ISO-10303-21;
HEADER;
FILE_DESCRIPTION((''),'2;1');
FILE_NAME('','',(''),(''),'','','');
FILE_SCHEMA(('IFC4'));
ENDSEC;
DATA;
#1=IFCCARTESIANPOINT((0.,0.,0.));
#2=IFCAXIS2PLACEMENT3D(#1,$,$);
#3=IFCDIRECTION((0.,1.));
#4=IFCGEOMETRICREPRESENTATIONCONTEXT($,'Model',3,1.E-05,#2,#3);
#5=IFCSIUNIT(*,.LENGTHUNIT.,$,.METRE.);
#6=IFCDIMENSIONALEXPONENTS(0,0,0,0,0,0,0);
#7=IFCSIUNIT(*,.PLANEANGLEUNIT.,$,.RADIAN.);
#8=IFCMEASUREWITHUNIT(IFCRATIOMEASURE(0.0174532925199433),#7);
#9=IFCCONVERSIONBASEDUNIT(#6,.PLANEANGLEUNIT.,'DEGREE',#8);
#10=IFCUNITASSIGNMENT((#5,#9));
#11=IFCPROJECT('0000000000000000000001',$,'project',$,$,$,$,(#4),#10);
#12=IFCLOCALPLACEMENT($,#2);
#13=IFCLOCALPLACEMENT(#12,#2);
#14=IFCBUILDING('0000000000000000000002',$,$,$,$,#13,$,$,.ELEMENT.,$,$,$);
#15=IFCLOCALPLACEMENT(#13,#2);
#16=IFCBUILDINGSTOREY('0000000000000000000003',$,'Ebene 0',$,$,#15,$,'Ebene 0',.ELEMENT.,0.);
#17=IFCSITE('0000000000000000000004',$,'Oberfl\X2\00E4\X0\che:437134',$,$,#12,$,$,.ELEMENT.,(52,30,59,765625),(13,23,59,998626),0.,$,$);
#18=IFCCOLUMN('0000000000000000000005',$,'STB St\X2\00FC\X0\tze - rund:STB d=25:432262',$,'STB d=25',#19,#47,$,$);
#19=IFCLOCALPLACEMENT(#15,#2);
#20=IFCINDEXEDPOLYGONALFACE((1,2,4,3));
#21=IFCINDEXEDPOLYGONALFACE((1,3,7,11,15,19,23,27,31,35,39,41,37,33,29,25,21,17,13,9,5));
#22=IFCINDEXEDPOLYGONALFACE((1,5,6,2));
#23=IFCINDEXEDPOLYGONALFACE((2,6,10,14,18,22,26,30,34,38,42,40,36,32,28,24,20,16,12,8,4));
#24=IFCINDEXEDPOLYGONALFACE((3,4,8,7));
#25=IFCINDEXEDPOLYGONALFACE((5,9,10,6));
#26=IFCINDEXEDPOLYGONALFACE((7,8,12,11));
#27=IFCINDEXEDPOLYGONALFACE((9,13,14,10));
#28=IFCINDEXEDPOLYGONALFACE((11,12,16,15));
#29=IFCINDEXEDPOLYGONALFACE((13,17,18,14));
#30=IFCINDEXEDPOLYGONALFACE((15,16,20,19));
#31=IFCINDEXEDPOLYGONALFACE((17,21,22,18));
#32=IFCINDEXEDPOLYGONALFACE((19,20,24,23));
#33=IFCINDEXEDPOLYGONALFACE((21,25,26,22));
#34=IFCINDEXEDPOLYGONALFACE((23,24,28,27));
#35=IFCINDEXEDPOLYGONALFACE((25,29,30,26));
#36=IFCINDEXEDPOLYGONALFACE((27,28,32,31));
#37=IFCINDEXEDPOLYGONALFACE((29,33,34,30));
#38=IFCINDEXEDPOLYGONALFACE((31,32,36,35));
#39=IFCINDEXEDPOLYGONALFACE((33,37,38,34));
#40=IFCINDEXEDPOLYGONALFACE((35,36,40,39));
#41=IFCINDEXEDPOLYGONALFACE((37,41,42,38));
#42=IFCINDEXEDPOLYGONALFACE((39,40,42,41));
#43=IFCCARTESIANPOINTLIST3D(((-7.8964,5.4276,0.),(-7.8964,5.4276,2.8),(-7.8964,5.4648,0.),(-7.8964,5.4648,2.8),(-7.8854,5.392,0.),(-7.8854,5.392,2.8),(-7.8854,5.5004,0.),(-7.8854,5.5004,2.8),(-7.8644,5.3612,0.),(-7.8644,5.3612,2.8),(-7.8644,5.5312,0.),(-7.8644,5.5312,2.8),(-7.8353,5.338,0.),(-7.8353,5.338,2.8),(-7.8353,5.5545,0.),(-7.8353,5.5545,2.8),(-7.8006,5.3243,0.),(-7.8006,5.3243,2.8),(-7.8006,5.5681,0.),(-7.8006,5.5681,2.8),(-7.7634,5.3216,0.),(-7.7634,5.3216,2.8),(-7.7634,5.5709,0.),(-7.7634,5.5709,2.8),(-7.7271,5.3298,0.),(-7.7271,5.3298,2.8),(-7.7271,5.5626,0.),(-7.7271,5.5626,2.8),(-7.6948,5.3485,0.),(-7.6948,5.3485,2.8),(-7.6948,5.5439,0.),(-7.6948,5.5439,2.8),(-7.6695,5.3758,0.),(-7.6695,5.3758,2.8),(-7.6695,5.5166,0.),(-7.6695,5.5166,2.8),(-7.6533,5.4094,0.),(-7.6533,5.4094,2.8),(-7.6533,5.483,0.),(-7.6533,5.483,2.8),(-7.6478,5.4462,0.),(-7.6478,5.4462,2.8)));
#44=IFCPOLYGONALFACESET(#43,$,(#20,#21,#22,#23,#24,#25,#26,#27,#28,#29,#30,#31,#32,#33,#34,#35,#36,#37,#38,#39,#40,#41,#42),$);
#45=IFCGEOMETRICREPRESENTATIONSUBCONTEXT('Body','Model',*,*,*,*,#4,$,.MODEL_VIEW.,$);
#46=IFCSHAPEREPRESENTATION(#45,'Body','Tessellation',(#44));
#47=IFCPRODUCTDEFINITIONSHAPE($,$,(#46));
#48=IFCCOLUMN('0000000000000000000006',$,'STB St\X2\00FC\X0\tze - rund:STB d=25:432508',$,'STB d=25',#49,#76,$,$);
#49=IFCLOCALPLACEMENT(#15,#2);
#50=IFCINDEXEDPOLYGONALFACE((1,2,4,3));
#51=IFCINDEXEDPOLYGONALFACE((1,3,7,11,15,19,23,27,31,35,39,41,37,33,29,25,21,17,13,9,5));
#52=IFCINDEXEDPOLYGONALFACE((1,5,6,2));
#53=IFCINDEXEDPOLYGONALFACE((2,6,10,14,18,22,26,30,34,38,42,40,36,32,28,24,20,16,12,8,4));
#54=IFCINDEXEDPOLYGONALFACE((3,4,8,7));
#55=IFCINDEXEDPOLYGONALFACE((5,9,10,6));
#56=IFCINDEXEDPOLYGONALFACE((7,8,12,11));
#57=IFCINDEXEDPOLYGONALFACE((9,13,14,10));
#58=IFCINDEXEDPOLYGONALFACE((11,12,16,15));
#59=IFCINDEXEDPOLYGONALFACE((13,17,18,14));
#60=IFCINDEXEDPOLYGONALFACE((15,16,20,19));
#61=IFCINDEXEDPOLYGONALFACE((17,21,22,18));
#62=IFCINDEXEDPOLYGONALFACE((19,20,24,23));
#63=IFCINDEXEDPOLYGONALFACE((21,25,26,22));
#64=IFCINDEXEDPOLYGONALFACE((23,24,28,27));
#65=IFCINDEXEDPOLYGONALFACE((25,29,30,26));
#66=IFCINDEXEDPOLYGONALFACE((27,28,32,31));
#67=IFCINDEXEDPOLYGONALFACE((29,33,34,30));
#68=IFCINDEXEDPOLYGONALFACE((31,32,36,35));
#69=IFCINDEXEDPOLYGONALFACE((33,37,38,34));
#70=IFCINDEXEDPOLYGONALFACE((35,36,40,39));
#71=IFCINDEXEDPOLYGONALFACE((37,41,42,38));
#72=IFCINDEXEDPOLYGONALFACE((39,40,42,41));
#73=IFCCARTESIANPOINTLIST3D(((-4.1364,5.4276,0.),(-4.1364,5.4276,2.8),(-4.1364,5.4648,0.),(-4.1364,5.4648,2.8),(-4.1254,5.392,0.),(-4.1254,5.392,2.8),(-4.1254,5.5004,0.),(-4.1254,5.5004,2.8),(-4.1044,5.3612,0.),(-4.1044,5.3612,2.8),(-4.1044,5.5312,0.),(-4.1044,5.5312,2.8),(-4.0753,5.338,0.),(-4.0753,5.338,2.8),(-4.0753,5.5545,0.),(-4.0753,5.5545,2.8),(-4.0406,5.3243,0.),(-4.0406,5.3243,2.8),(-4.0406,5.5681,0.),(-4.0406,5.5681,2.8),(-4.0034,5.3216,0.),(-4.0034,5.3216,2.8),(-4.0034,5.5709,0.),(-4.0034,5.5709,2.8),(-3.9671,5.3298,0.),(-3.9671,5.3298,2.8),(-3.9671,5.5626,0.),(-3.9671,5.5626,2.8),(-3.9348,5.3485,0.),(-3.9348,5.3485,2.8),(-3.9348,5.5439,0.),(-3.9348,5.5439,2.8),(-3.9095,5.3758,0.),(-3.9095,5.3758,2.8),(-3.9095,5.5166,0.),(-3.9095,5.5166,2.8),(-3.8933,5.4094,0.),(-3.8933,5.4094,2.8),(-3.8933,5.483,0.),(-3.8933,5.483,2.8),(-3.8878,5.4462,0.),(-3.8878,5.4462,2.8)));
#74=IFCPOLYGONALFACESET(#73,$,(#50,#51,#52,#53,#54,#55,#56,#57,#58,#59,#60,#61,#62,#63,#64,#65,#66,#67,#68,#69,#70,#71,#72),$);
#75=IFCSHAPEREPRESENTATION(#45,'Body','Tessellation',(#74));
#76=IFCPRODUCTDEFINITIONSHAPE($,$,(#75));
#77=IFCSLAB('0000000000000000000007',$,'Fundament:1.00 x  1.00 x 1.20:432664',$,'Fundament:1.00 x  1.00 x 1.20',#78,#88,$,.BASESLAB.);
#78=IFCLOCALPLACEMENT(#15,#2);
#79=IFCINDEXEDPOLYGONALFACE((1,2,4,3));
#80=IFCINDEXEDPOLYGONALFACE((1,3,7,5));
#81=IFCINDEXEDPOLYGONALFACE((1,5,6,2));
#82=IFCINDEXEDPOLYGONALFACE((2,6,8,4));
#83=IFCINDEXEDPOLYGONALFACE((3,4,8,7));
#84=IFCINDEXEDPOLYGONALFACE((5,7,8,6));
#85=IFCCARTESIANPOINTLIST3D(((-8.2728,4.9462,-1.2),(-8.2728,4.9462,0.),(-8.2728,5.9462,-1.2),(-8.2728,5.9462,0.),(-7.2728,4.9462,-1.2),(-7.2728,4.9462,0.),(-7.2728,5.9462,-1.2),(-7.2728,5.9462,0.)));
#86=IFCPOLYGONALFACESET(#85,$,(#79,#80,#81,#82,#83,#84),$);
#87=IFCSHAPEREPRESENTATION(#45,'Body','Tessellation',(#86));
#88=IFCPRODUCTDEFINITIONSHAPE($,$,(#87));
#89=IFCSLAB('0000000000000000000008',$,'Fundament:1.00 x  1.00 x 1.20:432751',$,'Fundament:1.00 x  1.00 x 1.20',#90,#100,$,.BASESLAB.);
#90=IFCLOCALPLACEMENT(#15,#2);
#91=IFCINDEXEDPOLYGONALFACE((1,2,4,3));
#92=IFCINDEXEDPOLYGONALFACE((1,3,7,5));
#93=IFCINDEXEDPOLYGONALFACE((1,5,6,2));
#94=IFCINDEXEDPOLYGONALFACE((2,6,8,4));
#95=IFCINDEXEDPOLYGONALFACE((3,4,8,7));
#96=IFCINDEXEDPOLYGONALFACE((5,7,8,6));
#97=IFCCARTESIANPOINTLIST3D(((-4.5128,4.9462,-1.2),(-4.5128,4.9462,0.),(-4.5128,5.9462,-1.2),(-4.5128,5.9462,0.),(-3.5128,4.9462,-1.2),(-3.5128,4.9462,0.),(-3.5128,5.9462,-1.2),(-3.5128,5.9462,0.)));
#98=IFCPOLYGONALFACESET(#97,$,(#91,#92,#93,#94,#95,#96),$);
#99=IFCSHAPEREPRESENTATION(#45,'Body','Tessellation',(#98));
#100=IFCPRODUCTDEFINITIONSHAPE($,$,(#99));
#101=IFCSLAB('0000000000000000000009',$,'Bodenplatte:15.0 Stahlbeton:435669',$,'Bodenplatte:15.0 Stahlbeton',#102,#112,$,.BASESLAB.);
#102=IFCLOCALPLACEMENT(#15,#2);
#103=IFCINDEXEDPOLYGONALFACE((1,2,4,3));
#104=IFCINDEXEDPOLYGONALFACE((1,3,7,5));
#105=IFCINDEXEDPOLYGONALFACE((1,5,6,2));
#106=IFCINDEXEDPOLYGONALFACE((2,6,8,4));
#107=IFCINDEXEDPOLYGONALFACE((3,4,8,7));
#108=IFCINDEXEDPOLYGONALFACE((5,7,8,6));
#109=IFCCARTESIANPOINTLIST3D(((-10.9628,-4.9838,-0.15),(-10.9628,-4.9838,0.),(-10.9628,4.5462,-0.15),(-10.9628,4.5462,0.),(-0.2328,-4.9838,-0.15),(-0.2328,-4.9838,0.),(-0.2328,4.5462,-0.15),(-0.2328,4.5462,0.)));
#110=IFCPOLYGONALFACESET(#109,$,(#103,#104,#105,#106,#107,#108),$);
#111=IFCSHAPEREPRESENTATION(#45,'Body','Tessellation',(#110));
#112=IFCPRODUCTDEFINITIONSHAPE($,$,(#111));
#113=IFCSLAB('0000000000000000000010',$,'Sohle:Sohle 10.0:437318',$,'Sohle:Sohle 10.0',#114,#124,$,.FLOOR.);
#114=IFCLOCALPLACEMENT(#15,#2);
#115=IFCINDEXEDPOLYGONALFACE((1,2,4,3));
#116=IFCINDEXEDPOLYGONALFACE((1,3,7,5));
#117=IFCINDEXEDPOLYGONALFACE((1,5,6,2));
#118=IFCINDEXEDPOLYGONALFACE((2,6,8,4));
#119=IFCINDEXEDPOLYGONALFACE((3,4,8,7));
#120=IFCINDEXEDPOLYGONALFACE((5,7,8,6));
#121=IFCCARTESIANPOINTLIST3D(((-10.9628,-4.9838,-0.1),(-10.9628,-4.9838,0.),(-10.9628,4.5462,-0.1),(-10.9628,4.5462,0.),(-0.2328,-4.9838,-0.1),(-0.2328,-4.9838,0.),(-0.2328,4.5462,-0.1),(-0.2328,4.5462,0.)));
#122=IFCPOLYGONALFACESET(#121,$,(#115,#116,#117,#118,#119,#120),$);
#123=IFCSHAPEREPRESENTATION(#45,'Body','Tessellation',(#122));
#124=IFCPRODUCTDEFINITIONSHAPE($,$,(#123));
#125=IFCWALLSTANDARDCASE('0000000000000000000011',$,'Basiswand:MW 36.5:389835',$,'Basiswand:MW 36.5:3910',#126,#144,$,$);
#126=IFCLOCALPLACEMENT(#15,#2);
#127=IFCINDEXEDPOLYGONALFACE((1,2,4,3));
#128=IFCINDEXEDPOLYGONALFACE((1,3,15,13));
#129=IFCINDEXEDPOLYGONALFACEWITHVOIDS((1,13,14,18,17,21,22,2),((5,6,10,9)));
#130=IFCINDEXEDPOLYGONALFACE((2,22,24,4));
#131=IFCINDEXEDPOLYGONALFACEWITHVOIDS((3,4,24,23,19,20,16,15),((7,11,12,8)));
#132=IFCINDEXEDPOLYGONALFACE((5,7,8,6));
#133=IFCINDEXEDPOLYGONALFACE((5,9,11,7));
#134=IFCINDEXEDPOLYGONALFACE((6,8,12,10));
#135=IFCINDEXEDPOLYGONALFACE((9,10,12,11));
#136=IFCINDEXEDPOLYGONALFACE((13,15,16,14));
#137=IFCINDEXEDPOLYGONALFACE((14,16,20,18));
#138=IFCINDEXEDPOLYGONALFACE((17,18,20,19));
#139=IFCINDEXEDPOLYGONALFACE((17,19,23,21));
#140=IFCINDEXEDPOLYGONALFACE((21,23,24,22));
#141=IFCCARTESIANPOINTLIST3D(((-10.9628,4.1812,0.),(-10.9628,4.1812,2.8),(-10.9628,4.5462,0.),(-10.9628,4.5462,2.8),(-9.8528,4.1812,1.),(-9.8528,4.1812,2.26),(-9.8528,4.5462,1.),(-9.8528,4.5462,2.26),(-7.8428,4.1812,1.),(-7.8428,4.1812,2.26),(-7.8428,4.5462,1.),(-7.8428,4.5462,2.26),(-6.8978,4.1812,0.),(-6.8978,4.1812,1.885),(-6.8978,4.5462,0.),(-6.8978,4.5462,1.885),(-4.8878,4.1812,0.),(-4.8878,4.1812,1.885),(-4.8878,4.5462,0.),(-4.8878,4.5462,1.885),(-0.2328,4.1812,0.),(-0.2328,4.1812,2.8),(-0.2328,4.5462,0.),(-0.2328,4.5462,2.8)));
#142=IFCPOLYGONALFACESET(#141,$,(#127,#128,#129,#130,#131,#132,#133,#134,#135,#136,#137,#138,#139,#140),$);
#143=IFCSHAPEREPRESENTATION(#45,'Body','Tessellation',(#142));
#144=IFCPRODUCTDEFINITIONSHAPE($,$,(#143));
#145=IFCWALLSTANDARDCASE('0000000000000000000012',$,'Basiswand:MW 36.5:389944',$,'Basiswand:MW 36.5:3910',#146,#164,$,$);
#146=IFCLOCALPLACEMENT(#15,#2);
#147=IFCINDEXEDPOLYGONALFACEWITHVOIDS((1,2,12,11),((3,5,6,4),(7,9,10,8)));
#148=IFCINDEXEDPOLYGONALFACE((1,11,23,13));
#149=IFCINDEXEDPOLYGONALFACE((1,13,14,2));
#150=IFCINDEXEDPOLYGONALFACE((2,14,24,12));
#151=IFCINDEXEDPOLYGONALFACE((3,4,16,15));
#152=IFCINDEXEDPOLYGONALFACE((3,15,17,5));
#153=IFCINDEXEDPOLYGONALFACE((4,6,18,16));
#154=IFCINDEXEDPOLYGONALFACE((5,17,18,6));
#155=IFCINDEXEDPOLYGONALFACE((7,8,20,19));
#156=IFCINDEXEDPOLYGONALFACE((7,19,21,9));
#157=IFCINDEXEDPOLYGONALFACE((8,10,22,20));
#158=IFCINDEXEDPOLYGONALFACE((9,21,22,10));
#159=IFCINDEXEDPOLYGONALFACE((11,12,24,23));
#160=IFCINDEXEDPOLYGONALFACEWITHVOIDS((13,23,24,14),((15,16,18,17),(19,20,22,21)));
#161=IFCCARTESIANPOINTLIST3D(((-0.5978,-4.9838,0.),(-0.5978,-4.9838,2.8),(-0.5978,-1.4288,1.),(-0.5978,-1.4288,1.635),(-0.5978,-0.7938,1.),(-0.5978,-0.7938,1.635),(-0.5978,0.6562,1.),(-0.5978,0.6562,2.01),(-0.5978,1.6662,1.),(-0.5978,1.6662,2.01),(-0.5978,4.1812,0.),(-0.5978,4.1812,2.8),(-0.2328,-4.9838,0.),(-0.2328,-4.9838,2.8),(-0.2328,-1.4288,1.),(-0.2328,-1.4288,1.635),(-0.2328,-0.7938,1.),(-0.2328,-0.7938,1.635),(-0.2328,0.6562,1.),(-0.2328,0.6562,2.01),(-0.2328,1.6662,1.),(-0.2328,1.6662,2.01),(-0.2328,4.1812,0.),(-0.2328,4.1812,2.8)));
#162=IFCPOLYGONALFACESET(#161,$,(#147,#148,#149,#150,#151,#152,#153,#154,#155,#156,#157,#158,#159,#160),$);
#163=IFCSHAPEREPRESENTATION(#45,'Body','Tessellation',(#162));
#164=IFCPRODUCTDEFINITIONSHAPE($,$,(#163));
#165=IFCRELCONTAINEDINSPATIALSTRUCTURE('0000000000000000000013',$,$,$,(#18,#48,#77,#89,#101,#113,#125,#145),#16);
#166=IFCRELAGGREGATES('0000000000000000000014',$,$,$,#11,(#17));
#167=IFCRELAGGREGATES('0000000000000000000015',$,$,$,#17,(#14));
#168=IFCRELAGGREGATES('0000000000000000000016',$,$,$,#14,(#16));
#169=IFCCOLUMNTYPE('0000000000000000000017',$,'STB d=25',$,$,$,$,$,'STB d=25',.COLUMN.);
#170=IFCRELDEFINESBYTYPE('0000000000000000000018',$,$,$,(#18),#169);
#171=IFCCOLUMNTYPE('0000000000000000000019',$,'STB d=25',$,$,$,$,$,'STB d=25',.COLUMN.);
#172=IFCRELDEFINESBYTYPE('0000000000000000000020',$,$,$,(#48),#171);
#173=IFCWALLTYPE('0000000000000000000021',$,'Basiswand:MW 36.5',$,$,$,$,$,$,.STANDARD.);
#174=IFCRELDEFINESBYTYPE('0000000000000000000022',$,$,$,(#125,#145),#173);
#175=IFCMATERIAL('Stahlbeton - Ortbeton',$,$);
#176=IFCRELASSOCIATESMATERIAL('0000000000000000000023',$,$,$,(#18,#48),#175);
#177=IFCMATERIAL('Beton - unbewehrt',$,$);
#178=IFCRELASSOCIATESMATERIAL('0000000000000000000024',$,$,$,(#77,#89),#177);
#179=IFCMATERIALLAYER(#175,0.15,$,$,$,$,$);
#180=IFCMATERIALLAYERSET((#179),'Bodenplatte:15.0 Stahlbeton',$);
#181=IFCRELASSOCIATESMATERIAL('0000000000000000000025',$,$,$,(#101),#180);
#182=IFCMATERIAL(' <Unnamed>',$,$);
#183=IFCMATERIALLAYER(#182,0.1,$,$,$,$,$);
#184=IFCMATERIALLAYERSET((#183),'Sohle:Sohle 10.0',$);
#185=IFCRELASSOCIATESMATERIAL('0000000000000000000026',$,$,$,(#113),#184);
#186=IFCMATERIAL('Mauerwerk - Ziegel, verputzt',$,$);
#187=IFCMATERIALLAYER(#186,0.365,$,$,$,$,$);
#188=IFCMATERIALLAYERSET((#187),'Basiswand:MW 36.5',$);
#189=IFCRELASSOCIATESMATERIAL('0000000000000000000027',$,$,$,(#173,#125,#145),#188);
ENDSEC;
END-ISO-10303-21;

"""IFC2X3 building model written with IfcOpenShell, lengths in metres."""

from ifc_helpers import new_model, entity, si_unit, converted_unit, direction, frame, frame_2d, origin, origin_2d_with_axis, place, context, subcontext, project, spatial, polyline, rectangle, circle, extrude, clip, bounded_halfspace, source, transform, mapped, material, layer, layer_set, layer_usage, type_object, type_shapes, element, save


model = new_model("IFC2X3")

# Units and contexts
model_context = context("Model", 3, precision=1e-05, world=origin(), true_north=direction((0.0, 1.0)))
body_context = subcontext(model_context, "Body", "Model", "MODEL_VIEW")
ifc_project = project(units=[si_unit("LENGTHUNIT", "METRE"), converted_unit("PLANEANGLEUNIT", "DEGREE", entity("IfcRatioMeasure", 0.0174532925199433), si_unit("PLANEANGLEUNIT", "RADIAN"), dimensions=[0, 0, 0, 0, 0, 0, 0])], contexts=[model_context])

# Site, building, storey
site_placement = place(None, origin())
site = spatial("IfcSite", under=ifc_project, at=site_placement, Name="Oberfläche:437134", CompositionType="ELEMENT", RefLatitude=(52, 30, 59, 765625), RefLongitude=(13, 23, 59, 998626), RefElevation=0.0)
building_placement = place(site_placement, origin())
building = spatial("IfcBuilding", under=site, at=building_placement, CompositionType="ELEMENT")
storey_placement = place(building_placement, origin())
storey = spatial("IfcBuildingStorey", under=building, at=storey_placement, Name="Ebene 0", LongName="Ebene 0", CompositionType="ELEMENT", Elevation=0.0)

# Columns
ifc_material_1 = material(Name="Stahlbeton - Ortbeton")
column_type_1 = type_object("IfcColumnType", Name="STB d=25", ElementType="STB d=25", PredefinedType="COLUMN")
shared_shape_1 = source(origin(), body_context, "Body", "SweptSolid", [
    extrude(circle(Radius=0.125, at=origin_2d_with_axis()), frame((-7.7728, 5.4462, 0.0)), (0.0, 0.0, 1.0), 2.8),
])
type_shapes(column_type_1, [shared_shape_1])
column_1_placement = place(storey_placement, origin())
element("IfcColumn", 1, at=column_1_placement, inside=storey, type_object=column_type_1, material=ifc_material_1, Name="STB Stütze - rund:STB d=25:432262", ObjectType="STB d=25", context=body_context, shape_type="MappedRepresentation", body=[
    mapped(shared_shape_1, transform((0.0, 0.0, 0.0), scale=1.0)),
])
column_type_2 = type_object("IfcColumnType", Name="STB d=25", ElementType="STB d=25", PredefinedType="COLUMN")
shared_shape_2 = source(origin(), body_context, "Body", "SweptSolid", [
    extrude(circle(Radius=0.125, at=origin_2d_with_axis()), frame((-4.0128, 5.4462, 0.0)), (0.0, 0.0, 1.0), 2.8),
])
type_shapes(column_type_2, [shared_shape_2])
column_2_placement = place(storey_placement, origin())
element("IfcColumn", 2, at=column_2_placement, inside=storey, type_object=column_type_2, material=ifc_material_1, Name="STB Stütze - rund:STB d=25:432508", ObjectType="STB d=25", context=body_context, shape_type="MappedRepresentation", body=[
    mapped(shared_shape_2, transform((0.0, 0.0, 0.0), scale=1.0)),
])

# Slabs
ifc_material_2 = material(Name="Beton - unbewehrt")
slab_1_placement = place(storey_placement, origin())
element("IfcSlab", 3, at=slab_1_placement, inside=storey, material=ifc_material_2, Name="Fundament:1.00 x  1.00 x 1.20:432664", ObjectType="Fundament:1.00 x  1.00 x 1.20", PredefinedType="BASESLAB", context=body_context, shape_type="SweptSolid", body=[
    extrude(rectangle(XDim=1.0, YDim=1.0, at=frame_2d((0.0, 0.0), x_axis=(1.0, 0.0))), frame((-7.7728, 5.4462, -1.2), z_axis=(0.0, 0.0, 1.0), x_axis=(-1.0, 0.0, 0.0)), (0.0, 0.0, 1.0), 1.2),
])
slab_2_placement = place(storey_placement, origin())
element("IfcSlab", 4, at=slab_2_placement, inside=storey, material=ifc_material_2, Name="Fundament:1.00 x  1.00 x 1.20:432751", ObjectType="Fundament:1.00 x  1.00 x 1.20", PredefinedType="BASESLAB", context=body_context, shape_type="SweptSolid", body=[
    extrude(rectangle(XDim=1.0, YDim=1.0, at=frame_2d((0.0, 0.0), x_axis=(1.0, 0.0))), frame((-4.0128, 5.4462, -1.2), z_axis=(0.0, 0.0, 1.0), x_axis=(-1.0, 0.0, 0.0)), (0.0, 0.0, 1.0), 1.2),
])
ifc_layer_1 = layer(ifc_material_1, 0.15)
ifc_layer_set_1 = layer_set([ifc_layer_1], Name="Bodenplatte:15.0 Stahlbeton")
ifc_layer_usage_1 = layer_usage(ifc_layer_set_1, "AXIS3", "POSITIVE", 0.0)
slab_3_placement = place(storey_placement, origin())
element("IfcSlab", 5, at=slab_3_placement, inside=storey, material=ifc_layer_usage_1, Name="Bodenplatte:15.0 Stahlbeton:435669", ObjectType="Bodenplatte:15.0 Stahlbeton", PredefinedType="BASESLAB", context=body_context, shape_type="SweptSolid", body=[
    extrude(rectangle(XDim=9.53, YDim=10.73, at=origin_2d_with_axis()), frame((-5.5978, -0.2188, 0.0), z_axis=(0.0, 0.0, -1.0), x_axis=(0.0, 1.0, 0.0)), (0.0, 0.0, 1.0), 0.15),
])
ifc_material_3 = material(Name=" <Unnamed>")
ifc_layer_2 = layer(ifc_material_3, 0.1)
ifc_layer_set_2 = layer_set([ifc_layer_2], Name="Sohle:Sohle 10.0")
ifc_layer_usage_2 = layer_usage(ifc_layer_set_2, "AXIS3", "POSITIVE", 0.0)
slab_4_placement = place(storey_placement, origin())
element("IfcSlab", 6, at=slab_4_placement, inside=storey, material=ifc_layer_usage_2, Name="Sohle:Sohle 10.0:437318", ObjectType="Sohle:Sohle 10.0", PredefinedType="FLOOR", context=body_context, shape_type="SweptSolid", body=[
    extrude(rectangle(XDim=9.53, YDim=10.73, at=frame_2d((0.0, 0.0), x_axis=(1.0, 0.0))), frame((-5.5978, -0.2188, -0.1), z_axis=(0.0, 0.0, 1.0), x_axis=(0.0, -1.0, 0.0)), (0.0, 0.0, 1.0), 0.1),
])

# Walls, openings
ifc_material_4 = material(Name="Mauerwerk - Ziegel, verputzt")
ifc_layer_3 = layer(ifc_material_4, 0.365)
ifc_layer_set_3 = layer_set([ifc_layer_3], Name="Basiswand:MW 36.5")
ifc_layer_usage_3 = layer_usage(ifc_layer_set_3, "AXIS2", "NEGATIVE", 0.1825)
wall_type_1 = type_object("IfcWallType", Name="Basiswand:MW 36.5", PredefinedType="STANDARD", material=ifc_layer_set_3)
wall_1_placement = place(storey_placement, frame((-10.9628, 4.3637, 0.0)))
wall_1 = element("IfcWallStandardCase", 7, at=wall_1_placement, inside=storey, type_object=wall_type_1, material=ifc_layer_usage_3, Name="Basiswand:MW 36.5:389835", ObjectType="Basiswand:MW 36.5:3910", context=body_context, shape_type="Clipping", body=[
    clip(extrude(rectangle(XDim=10.73, YDim=0.365, at=frame_2d((5.365, 0.0), x_axis=(-1.0, 0.0))), origin(), (0.0, 0.0, 1.0), 2.8), bounded_halfspace(frame((0.0, 0.1825, 2.8), z_axis=(0.0, 0.0, -1.0), x_axis=(0.0, 1.0, 0.0)), True, frame((0.0, 0.1825, 2.8)), polyline([(0.0, 0.0), (0.0, -0.365), (0.365, -0.365), (10.365, -0.365), (10.73, -0.365), (10.73, 0.0), (7.365, 0.0), (2.765, 0.0), (0.0, 0.0)]))),
])
opening_1_placement = place(wall_1_placement, frame((6.075, 0.1825, 0.0)))
element("IfcOpeningElement", 8, at=opening_1_placement, cuts=wall_1, ObjectType="Opening", context=body_context, shape_type="SweptSolid", body=[
    extrude(rectangle(XDim=1.885, YDim=2.01, at=frame_2d((0.9425, 1.005), x_axis=(1.0, 0.0))), frame((0.0, 0.0, 0.0), z_axis=(0.0, -1.0, 0.0), x_axis=(0.0, 0.0, 1.0)), (0.0, 0.0, 1.0), 0.365),
])
opening_2_placement = place(wall_1_placement, frame((3.12, 0.1825, 1.0)))
element("IfcOpeningElement", 9, at=opening_2_placement, cuts=wall_1, ObjectType="Opening", context=body_context, shape_type="SweptSolid", body=[
    extrude(rectangle(XDim=1.26, YDim=2.01, at=frame_2d((0.63, 1.005), x_axis=(1.0, 0.0))), frame((0.0, 0.0, 0.0), z_axis=(0.0, -1.0, 0.0), x_axis=(0.0, 0.0, 1.0)), (0.0, 0.0, 1.0), 0.365),
])
ifc_layer_usage_4 = layer_usage(ifc_layer_set_3, "AXIS2", "NEGATIVE", 0.1825)
wall_2_placement = place(storey_placement, frame((-0.4153, 4.1812, 0.0), z_axis=(0.0, 0.0, 1.0), x_axis=(0.0, -1.0, 0.0)))
wall_2 = element("IfcWallStandardCase", 10, at=wall_2_placement, inside=storey, type_object=wall_type_1, material=ifc_layer_usage_4, Name="Basiswand:MW 36.5:389944", ObjectType="Basiswand:MW 36.5:3910", context=body_context, shape_type="Clipping", body=[
    clip(extrude(rectangle(XDim=9.165, YDim=0.365, at=frame_2d((4.5825, 0.0), x_axis=(-1.0, 0.0))), origin(), (0.0, 0.0, 1.0), 2.8), bounded_halfspace(frame((0.0, -0.1825, 2.8), z_axis=(0.0, 0.0, -1.0), x_axis=(-1.0, 0.0, 0.0)), True, frame((0.0, -0.1825, 2.8)), polyline([(0.0, 0.0), (4.5, 0.0), (4.675, 0.0), (7.1, 0.0), (7.275, 0.0), (8.8, 0.0), (9.165, 0.0), (9.165, 0.365), (0.0, 0.365), (0.0, 0.0)]))),
])
opening_3_placement = place(wall_2_placement, frame((5.61, 0.1825, 1.0)))
element("IfcOpeningElement", 11, at=opening_3_placement, cuts=wall_2, ObjectType="Opening", context=body_context, shape_type="SweptSolid", body=[
    extrude(rectangle(XDim=0.635, YDim=0.635, at=frame_2d((0.3175, 0.3175), x_axis=(1.0, 0.0))), frame((0.0, 0.0, 0.0), z_axis=(0.0, -1.0, 0.0), x_axis=(0.0, 0.0, 1.0)), (0.0, 0.0, 1.0), 0.365),
])
opening_4_placement = place(wall_2_placement, frame((3.525, 0.1825, 1.0)))
element("IfcOpeningElement", 12, at=opening_4_placement, cuts=wall_2, ObjectType="Opening", context=body_context, shape_type="SweptSolid", body=[
    extrude(rectangle(XDim=1.01, YDim=1.01, at=frame_2d((0.505, 0.505), x_axis=(1.0, 0.0))), frame((0.0, 0.0, 0.0), z_axis=(0.0, -1.0, 0.0), x_axis=(0.0, 0.0, 1.0)), (0.0, 0.0, 1.0), 0.365),
])

save(model, "model.ifc")
